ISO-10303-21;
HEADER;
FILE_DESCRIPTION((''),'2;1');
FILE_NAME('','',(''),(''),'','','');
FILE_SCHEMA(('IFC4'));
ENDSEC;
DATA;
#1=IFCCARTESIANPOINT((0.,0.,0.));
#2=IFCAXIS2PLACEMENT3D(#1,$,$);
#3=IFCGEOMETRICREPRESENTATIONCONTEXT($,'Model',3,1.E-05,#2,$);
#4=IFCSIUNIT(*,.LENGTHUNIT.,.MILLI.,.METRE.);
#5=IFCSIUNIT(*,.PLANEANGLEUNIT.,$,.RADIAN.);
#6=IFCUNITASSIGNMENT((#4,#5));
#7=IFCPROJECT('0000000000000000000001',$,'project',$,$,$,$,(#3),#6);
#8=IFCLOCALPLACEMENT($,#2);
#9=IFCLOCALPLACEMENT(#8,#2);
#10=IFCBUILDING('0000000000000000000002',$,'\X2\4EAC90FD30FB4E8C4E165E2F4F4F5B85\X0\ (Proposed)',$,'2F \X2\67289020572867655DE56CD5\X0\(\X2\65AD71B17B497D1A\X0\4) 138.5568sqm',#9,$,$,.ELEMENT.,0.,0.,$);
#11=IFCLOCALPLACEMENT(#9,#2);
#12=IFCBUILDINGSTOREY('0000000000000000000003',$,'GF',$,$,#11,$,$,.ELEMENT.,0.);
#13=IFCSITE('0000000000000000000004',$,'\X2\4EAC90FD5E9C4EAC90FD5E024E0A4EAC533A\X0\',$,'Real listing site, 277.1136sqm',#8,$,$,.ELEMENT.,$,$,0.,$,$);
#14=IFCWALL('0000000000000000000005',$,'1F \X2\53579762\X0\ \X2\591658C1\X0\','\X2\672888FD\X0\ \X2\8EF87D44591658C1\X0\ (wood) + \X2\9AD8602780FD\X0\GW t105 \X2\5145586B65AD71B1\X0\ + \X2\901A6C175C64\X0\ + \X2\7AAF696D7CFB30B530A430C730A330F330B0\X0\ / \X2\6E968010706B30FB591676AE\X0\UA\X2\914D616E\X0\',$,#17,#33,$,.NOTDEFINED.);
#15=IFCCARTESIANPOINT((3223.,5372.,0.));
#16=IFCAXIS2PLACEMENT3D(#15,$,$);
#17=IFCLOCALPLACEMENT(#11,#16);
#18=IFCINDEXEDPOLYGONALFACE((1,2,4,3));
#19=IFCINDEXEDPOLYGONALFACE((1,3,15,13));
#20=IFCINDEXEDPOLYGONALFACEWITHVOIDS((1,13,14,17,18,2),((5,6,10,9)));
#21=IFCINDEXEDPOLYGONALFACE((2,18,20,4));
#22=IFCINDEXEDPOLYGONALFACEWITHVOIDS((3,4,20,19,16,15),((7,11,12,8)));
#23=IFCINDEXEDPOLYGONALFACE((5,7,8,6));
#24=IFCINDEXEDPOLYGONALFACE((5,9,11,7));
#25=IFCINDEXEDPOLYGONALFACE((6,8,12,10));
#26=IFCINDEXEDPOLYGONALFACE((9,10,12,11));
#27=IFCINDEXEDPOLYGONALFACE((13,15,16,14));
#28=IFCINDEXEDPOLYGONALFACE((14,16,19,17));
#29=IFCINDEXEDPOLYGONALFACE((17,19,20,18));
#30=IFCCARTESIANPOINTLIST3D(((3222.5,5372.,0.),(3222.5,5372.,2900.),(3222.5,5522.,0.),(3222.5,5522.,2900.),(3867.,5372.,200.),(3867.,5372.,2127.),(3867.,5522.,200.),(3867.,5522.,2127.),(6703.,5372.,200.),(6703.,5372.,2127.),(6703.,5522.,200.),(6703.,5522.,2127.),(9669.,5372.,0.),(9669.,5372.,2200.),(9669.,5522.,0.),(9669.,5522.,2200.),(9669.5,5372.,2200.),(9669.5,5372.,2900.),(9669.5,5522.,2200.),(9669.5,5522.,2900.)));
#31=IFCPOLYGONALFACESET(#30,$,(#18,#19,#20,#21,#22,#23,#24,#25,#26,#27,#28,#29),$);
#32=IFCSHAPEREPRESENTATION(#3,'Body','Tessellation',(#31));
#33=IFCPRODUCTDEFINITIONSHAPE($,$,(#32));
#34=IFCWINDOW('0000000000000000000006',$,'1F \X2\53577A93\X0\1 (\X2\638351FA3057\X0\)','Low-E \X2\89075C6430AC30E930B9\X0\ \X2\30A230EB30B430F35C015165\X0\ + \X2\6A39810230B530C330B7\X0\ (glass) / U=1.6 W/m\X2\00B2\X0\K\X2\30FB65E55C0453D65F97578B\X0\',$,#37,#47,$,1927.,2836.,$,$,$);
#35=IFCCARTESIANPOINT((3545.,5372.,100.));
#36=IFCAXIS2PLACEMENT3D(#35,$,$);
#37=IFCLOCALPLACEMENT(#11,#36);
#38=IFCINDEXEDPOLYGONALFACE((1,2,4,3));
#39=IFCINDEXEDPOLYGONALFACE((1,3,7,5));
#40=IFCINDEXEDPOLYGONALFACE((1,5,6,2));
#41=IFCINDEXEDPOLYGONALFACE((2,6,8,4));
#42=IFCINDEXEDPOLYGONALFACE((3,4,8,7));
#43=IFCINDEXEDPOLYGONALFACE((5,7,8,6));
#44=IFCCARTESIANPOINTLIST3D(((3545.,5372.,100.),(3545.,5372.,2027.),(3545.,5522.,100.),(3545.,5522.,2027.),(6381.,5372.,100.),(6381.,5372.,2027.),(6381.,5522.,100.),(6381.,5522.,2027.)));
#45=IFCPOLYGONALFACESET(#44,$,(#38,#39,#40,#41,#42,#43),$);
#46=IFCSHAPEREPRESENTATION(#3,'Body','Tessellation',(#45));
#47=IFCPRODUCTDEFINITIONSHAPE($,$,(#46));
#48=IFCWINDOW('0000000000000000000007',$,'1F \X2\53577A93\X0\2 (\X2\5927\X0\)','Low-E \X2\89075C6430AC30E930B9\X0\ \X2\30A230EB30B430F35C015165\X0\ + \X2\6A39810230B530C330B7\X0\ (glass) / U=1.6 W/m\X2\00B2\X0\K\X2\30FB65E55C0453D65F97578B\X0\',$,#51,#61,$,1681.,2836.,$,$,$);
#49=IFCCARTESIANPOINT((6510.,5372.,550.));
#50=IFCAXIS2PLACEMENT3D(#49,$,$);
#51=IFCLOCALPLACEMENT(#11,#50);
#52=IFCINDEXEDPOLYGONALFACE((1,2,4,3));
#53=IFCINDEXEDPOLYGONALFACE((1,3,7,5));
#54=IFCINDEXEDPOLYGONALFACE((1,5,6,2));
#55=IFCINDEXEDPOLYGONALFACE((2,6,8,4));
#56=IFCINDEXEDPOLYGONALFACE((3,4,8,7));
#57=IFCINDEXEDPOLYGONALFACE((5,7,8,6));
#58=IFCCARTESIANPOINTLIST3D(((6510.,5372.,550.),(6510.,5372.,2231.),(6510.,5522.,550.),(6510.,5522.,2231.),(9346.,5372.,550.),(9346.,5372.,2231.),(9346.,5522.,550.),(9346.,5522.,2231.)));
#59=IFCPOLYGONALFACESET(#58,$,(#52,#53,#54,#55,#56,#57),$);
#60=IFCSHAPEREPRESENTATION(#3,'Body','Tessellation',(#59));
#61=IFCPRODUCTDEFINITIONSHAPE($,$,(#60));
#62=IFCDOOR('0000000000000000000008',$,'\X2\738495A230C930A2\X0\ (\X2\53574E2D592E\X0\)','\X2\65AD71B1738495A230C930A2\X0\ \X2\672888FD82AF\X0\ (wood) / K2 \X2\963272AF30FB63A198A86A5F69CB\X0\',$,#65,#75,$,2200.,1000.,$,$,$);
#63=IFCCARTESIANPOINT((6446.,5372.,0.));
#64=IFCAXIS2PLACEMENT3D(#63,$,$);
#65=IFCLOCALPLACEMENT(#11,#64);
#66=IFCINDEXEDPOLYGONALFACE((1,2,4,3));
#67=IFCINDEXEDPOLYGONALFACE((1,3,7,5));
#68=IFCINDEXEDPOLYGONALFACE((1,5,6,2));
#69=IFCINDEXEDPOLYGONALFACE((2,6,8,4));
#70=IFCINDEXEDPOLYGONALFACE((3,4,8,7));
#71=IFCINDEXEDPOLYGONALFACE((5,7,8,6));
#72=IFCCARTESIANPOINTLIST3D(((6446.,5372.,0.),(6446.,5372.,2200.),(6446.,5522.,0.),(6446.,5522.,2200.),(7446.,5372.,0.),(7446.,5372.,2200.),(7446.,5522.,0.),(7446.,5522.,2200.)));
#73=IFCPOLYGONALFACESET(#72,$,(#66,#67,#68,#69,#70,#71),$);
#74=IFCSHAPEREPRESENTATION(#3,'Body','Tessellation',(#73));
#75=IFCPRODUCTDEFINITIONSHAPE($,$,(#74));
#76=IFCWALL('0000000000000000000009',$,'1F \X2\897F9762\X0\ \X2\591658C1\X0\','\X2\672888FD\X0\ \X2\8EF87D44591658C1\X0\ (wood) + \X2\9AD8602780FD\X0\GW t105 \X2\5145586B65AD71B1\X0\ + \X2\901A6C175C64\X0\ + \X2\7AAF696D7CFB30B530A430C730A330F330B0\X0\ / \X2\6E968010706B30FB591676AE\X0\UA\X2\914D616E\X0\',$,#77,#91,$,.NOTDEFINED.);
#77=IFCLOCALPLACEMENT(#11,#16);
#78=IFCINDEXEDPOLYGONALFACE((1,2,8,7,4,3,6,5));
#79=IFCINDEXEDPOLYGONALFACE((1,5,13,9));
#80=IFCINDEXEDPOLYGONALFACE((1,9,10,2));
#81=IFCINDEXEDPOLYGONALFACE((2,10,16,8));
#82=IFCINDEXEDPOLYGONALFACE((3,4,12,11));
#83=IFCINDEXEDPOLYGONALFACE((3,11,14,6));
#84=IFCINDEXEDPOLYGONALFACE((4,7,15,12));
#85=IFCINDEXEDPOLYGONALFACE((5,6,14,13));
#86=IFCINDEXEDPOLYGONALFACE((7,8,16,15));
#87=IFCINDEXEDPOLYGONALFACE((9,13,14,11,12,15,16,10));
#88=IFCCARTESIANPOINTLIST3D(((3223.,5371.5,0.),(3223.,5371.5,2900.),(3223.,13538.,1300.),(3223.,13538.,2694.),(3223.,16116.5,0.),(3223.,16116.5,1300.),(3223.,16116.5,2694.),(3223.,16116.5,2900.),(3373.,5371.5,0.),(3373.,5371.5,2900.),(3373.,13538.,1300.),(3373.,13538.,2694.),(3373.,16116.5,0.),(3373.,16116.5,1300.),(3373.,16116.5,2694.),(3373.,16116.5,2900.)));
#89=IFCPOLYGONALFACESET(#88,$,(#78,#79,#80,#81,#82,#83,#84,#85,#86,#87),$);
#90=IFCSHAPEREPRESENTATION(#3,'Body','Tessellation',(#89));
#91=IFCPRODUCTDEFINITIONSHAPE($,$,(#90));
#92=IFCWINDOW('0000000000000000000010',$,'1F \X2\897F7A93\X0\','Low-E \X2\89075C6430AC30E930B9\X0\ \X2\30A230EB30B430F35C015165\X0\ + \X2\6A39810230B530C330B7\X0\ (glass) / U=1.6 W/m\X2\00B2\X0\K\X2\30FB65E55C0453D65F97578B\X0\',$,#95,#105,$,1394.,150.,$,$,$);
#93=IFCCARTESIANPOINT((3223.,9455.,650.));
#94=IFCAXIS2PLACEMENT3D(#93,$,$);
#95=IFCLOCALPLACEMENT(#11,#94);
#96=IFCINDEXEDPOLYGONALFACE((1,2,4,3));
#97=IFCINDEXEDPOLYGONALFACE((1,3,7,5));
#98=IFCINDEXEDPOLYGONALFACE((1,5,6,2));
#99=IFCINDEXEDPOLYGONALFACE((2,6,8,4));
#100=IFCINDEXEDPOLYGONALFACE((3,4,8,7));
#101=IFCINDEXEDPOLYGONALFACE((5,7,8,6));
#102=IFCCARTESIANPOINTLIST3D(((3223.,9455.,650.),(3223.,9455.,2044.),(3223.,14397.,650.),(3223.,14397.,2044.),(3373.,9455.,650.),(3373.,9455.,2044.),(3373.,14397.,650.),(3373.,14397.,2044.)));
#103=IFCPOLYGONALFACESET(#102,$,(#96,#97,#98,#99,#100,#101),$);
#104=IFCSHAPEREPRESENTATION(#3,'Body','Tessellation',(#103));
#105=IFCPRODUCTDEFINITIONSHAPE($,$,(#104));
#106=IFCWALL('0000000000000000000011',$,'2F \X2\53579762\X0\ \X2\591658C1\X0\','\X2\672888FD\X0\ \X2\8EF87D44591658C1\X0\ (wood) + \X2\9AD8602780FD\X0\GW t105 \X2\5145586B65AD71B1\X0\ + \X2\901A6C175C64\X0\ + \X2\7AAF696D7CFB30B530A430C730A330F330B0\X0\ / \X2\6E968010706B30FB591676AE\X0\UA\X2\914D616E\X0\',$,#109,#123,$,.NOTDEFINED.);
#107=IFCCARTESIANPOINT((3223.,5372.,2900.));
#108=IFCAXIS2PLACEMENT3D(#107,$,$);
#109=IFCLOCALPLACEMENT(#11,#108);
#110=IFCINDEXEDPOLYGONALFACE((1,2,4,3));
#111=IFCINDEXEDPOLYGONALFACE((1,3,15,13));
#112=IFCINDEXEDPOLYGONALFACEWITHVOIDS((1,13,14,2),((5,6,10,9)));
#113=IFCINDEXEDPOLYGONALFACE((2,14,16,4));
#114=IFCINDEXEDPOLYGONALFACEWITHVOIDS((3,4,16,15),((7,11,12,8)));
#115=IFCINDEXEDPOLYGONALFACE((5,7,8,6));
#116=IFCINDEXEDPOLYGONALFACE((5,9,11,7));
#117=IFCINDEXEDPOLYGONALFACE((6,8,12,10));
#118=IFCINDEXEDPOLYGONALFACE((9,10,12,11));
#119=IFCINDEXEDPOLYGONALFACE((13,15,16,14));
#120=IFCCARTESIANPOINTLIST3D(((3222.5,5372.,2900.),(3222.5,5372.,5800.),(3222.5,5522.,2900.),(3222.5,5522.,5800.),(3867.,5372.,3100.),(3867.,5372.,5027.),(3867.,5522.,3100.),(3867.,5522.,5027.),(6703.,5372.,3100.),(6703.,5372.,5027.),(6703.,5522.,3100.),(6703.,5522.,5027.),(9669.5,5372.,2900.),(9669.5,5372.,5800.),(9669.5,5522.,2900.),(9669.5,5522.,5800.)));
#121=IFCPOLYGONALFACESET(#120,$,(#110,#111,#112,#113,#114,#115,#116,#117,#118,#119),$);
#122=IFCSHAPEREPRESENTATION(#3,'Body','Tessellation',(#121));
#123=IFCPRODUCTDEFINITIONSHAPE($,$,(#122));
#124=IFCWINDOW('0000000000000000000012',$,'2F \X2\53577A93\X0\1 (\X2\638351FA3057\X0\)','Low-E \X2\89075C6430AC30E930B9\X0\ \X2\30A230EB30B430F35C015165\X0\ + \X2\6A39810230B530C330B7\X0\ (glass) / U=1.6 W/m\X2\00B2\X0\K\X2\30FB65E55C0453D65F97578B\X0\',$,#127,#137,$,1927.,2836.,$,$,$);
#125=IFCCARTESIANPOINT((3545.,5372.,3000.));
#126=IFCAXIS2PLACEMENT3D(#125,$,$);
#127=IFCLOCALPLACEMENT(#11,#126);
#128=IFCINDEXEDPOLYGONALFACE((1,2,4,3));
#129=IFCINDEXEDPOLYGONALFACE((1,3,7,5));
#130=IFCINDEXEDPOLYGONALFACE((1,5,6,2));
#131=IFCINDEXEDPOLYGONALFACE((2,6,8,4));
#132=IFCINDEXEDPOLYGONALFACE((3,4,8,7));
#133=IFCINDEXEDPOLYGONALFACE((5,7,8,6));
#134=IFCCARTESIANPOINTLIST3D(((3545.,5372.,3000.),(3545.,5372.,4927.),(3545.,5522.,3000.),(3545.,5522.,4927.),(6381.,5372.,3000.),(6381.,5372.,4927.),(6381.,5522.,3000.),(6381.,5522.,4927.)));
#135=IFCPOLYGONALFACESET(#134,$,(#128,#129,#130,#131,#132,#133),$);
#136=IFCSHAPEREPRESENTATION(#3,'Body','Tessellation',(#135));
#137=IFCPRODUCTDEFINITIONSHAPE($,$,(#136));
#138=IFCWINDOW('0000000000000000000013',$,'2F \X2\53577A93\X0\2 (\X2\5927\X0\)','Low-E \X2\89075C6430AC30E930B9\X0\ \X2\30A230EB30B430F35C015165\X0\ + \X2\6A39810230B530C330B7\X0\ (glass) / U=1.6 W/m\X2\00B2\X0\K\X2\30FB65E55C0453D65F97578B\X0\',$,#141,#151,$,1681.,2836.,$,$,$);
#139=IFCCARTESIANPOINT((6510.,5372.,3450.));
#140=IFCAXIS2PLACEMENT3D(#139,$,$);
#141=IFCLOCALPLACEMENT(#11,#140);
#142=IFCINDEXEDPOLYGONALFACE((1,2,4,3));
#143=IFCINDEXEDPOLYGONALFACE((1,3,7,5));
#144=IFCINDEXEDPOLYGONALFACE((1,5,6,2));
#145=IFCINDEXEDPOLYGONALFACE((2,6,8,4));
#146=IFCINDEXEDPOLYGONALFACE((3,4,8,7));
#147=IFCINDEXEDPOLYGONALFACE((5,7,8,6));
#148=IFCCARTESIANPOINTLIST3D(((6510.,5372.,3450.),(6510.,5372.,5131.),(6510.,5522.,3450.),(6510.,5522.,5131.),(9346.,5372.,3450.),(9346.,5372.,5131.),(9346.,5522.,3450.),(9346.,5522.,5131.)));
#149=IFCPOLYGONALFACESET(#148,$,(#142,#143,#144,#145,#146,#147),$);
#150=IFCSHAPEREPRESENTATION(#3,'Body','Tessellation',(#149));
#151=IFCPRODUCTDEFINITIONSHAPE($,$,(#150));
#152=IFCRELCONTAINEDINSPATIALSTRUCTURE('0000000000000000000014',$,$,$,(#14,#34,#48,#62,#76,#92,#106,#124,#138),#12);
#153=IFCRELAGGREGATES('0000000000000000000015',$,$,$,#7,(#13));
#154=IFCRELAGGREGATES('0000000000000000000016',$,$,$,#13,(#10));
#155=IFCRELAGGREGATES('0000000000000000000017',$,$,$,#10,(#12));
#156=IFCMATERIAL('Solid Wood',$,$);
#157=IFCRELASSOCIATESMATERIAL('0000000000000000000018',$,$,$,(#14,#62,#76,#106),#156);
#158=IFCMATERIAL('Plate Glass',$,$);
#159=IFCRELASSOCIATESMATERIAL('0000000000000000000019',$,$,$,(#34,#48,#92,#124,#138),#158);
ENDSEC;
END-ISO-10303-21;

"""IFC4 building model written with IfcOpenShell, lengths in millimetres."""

from ifc_helpers import new_model, si_unit, frame, frame_2d, origin, place, context, project, spatial, rectangle, extrude, material, element, fill, save


model = new_model("IFC4")

# Units and contexts
model_context = context("Model", 3, precision=1e-05, world=origin())
ifc_project = project(units=[si_unit("LENGTHUNIT", "METRE", prefix="MILLI"), si_unit("PLANEANGLEUNIT", "RADIAN")], contexts=[model_context])

# Site, building, storey
site_placement = place(None, origin())
site = spatial("IfcSite", under=ifc_project, at=site_placement, Name="京都府京都市上京区", ObjectType="Real listing site, 277.1136sqm", CompositionType="ELEMENT", RefElevation=0.0)
building_placement = place(site_placement, origin())
building = spatial("IfcBuilding", under=site, at=building_placement, Name="京都・二世帯住宅 (Proposed)", ObjectType="2F 木造在来工法(断熱等級4) 138.5568sqm", CompositionType="ELEMENT", ElevationOfRefHeight=0.0, ElevationOfTerrain=0.0)
storey_placement = place(building_placement, origin())
storey = spatial("IfcBuildingStorey", under=building, at=storey_placement, Name="GF", CompositionType="ELEMENT", Elevation=0.0)

# Shared definitions
ifc_material_1 = material(Name="Solid Wood")

# Wall, openings, windows, door
wall_1_placement = place(storey_placement, frame((3223.0, 5372.0, 0.0)))
wall_1 = element("IfcWall", 1, at=wall_1_placement, inside=storey, material=ifc_material_1, Name="1F 南面 外壁", Description="木製 軸組外壁 (wood) + 高性能GW t105 充填断熱 + 通気層 + 窯業系サイディング / 準耐火・外皮UA配慮", PredefinedType="NOTDEFINED", context=model_context, shape_type="SweptSolid", body=[
    extrude(rectangle(XDim=6447.0, YDim=150.0, at=frame_2d((3223.0, 75.0))), frame((3223.0, 5372.0, 0.0)), (0.0, 0.0, 1.0), 2900.0),
])
opening_1_placement = place(storey_placement, frame((3545.0, 5372.0, 100.0)))
opening_1 = element("IfcOpeningElement", 2, at=opening_1_placement, cuts=wall_1, PredefinedType="NOTDEFINED", context=model_context, shape_type="SweptSolid", body=[
    extrude(rectangle(XDim=2836.0, YDim=150.0, at=frame_2d((1418.0, 75.0))), frame((3545.0, 5372.0, 100.0)), (0.0, 0.0, 1.0), 1927.0),
])
opening_2_placement = place(storey_placement, frame((6510.0, 5372.0, 550.0)))
opening_2 = element("IfcOpeningElement", 3, at=opening_2_placement, cuts=wall_1, PredefinedType="NOTDEFINED", context=model_context, shape_type="SweptSolid", body=[
    extrude(rectangle(XDim=2836.0, YDim=150.0, at=frame_2d((1418.0, 75.0))), frame((6510.0, 5372.0, 550.0)), (0.0, 0.0, 1.0), 1681.0),
])
opening_3_placement = place(storey_placement, frame((6446.0, 5372.0, 0.0)))
opening_3 = element("IfcOpeningElement", 4, at=opening_3_placement, cuts=wall_1, PredefinedType="NOTDEFINED", context=model_context, shape_type="SweptSolid", body=[
    extrude(rectangle(XDim=1000.0, YDim=150.0, at=frame_2d((500.0, 75.0))), frame((6446.0, 5372.0, 0.0)), (0.0, 0.0, 1.0), 2200.0),
])
ifc_material_2 = material(Name="Plate Glass")
window_1_placement = place(storey_placement, frame((3545.0, 5372.0, 100.0)))
window_1 = element("IfcWindow", 5, at=window_1_placement, inside=storey, material=ifc_material_2, Name="1F 南窓1 (掃出し)", Description="Low-E 複層ガラス アルゴン封入 + 樹脂サッシ (glass) / U=1.6 W/m²K・日射取得型", OverallHeight=1927.0, OverallWidth=2836.0, context=model_context, shape_type="SweptSolid", body=[
    extrude(rectangle(XDim=2836.0, YDim=150.0, at=frame_2d((1418.0, 75.0))), frame((3545.0, 5372.0, 100.0)), (0.0, 0.0, 1.0), 1927.0),
])
fill(opening_1, window_1)
window_2_placement = place(storey_placement, frame((6510.0, 5372.0, 550.0)))
window_2 = element("IfcWindow", 6, at=window_2_placement, inside=storey, material=ifc_material_2, Name="1F 南窓2 (大)", Description="Low-E 複層ガラス アルゴン封入 + 樹脂サッシ (glass) / U=1.6 W/m²K・日射取得型", OverallHeight=1681.0, OverallWidth=2836.0, context=model_context, shape_type="SweptSolid", body=[
    extrude(rectangle(XDim=2836.0, YDim=150.0, at=frame_2d((1418.0, 75.0))), frame((6510.0, 5372.0, 550.0)), (0.0, 0.0, 1.0), 1681.0),
])
fill(opening_2, window_2)
door_placement = place(storey_placement, frame((6446.0, 5372.0, 0.0)))
door = element("IfcDoor", 7, at=door_placement, inside=storey, material=ifc_material_1, Name="玄関ドア (南中央)", Description="断熱玄関ドア 木製芯 (wood) / K2 防犯・採風機構", OverallHeight=2200.0, OverallWidth=1000.0, context=model_context, shape_type="SweptSolid", body=[
    extrude(rectangle(XDim=1000.0, YDim=150.0, at=frame_2d((500.0, 75.0))), frame((6446.0, 5372.0, 0.0)), (0.0, 0.0, 1.0), 2200.0),
])
fill(opening_3, door)

# Wall, opening, window
wall_2_placement = place(storey_placement, frame((3223.0, 5372.0, 0.0)))
wall_2 = element("IfcWall", 8, at=wall_2_placement, inside=storey, material=ifc_material_1, Name="1F 西面 外壁", Description="木製 軸組外壁 (wood) + 高性能GW t105 充填断熱 + 通気層 + 窯業系サイディング / 準耐火・外皮UA配慮", PredefinedType="NOTDEFINED", context=model_context, shape_type="SweptSolid", body=[
    extrude(rectangle(XDim=150.0, YDim=10745.0, at=frame_2d((75.0, 5372.0))), frame((3223.0, 5372.0, 0.0)), (0.0, 0.0, 1.0), 2900.0),
])
opening_4_placement = place(storey_placement, frame((3223.0, 9455.0, 650.0)))
opening_4 = element("IfcOpeningElement", 9, at=opening_4_placement, cuts=wall_2, PredefinedType="NOTDEFINED", context=model_context, shape_type="SweptSolid", body=[
    extrude(rectangle(XDim=150.0, YDim=4942.0, at=frame_2d((75.0, 2471.0))), frame((3223.0, 9455.0, 650.0)), (0.0, 0.0, 1.0), 1394.0),
])
window_3_placement = place(storey_placement, frame((3223.0, 9455.0, 650.0)))
window_3 = element("IfcWindow", 10, at=window_3_placement, inside=storey, material=ifc_material_2, Name="1F 西窓", Description="Low-E 複層ガラス アルゴン封入 + 樹脂サッシ (glass) / U=1.6 W/m²K・日射取得型", OverallHeight=1394.0, OverallWidth=150.0, context=model_context, shape_type="SweptSolid", body=[
    extrude(rectangle(XDim=150.0, YDim=4942.0, at=frame_2d((75.0, 2471.0))), frame((3223.0, 9455.0, 650.0)), (0.0, 0.0, 1.0), 1394.0),
])
fill(opening_4, window_3)

# Wall, openings, windows
wall_3_placement = place(storey_placement, frame((3223.0, 5372.0, 2900.0)))
wall_3 = element("IfcWall", 11, at=wall_3_placement, inside=storey, material=ifc_material_1, Name="2F 南面 外壁", Description="木製 軸組外壁 (wood) + 高性能GW t105 充填断熱 + 通気層 + 窯業系サイディング / 準耐火・外皮UA配慮", PredefinedType="NOTDEFINED", context=model_context, shape_type="SweptSolid", body=[
    extrude(rectangle(XDim=6447.0, YDim=150.0, at=frame_2d((3223.0, 75.0))), frame((3223.0, 5372.0, 2900.0)), (0.0, 0.0, 1.0), 2900.0),
])
opening_5_placement = place(storey_placement, frame((3545.0, 5372.0, 3000.0)))
opening_5 = element("IfcOpeningElement", 12, at=opening_5_placement, cuts=wall_3, PredefinedType="NOTDEFINED", context=model_context, shape_type="SweptSolid", body=[
    extrude(rectangle(XDim=2836.0, YDim=150.0, at=frame_2d((1418.0, 75.0))), frame((3545.0, 5372.0, 3000.0)), (0.0, 0.0, 1.0), 1927.0),
])
opening_6_placement = place(storey_placement, frame((6510.0, 5372.0, 3450.0)))
opening_6 = element("IfcOpeningElement", 13, at=opening_6_placement, cuts=wall_3, PredefinedType="NOTDEFINED", context=model_context, shape_type="SweptSolid", body=[
    extrude(rectangle(XDim=2836.0, YDim=150.0, at=frame_2d((1418.0, 75.0))), frame((6510.0, 5372.0, 3450.0)), (0.0, 0.0, 1.0), 1681.0),
])
window_4_placement = place(storey_placement, frame((3545.0, 5372.0, 3000.0)))
window_4 = element("IfcWindow", 14, at=window_4_placement, inside=storey, material=ifc_material_2, Name="2F 南窓1 (掃出し)", Description="Low-E 複層ガラス アルゴン封入 + 樹脂サッシ (glass) / U=1.6 W/m²K・日射取得型", OverallHeight=1927.0, OverallWidth=2836.0, context=model_context, shape_type="SweptSolid", body=[
    extrude(rectangle(XDim=2836.0, YDim=150.0, at=frame_2d((1418.0, 75.0))), frame((3545.0, 5372.0, 3000.0)), (0.0, 0.0, 1.0), 1927.0),
])
fill(opening_5, window_4)
window_5_placement = place(storey_placement, frame((6510.0, 5372.0, 3450.0)))
window_5 = element("IfcWindow", 15, at=window_5_placement, inside=storey, material=ifc_material_2, Name="2F 南窓2 (大)", Description="Low-E 複層ガラス アルゴン封入 + 樹脂サッシ (glass) / U=1.6 W/m²K・日射取得型", OverallHeight=1681.0, OverallWidth=2836.0, context=model_context, shape_type="SweptSolid", body=[
    extrude(rectangle(XDim=2836.0, YDim=150.0, at=frame_2d((1418.0, 75.0))), frame((6510.0, 5372.0, 3450.0)), (0.0, 0.0, 1.0), 1681.0),
])
fill(opening_6, window_5)

save(model, "model.ifc")
